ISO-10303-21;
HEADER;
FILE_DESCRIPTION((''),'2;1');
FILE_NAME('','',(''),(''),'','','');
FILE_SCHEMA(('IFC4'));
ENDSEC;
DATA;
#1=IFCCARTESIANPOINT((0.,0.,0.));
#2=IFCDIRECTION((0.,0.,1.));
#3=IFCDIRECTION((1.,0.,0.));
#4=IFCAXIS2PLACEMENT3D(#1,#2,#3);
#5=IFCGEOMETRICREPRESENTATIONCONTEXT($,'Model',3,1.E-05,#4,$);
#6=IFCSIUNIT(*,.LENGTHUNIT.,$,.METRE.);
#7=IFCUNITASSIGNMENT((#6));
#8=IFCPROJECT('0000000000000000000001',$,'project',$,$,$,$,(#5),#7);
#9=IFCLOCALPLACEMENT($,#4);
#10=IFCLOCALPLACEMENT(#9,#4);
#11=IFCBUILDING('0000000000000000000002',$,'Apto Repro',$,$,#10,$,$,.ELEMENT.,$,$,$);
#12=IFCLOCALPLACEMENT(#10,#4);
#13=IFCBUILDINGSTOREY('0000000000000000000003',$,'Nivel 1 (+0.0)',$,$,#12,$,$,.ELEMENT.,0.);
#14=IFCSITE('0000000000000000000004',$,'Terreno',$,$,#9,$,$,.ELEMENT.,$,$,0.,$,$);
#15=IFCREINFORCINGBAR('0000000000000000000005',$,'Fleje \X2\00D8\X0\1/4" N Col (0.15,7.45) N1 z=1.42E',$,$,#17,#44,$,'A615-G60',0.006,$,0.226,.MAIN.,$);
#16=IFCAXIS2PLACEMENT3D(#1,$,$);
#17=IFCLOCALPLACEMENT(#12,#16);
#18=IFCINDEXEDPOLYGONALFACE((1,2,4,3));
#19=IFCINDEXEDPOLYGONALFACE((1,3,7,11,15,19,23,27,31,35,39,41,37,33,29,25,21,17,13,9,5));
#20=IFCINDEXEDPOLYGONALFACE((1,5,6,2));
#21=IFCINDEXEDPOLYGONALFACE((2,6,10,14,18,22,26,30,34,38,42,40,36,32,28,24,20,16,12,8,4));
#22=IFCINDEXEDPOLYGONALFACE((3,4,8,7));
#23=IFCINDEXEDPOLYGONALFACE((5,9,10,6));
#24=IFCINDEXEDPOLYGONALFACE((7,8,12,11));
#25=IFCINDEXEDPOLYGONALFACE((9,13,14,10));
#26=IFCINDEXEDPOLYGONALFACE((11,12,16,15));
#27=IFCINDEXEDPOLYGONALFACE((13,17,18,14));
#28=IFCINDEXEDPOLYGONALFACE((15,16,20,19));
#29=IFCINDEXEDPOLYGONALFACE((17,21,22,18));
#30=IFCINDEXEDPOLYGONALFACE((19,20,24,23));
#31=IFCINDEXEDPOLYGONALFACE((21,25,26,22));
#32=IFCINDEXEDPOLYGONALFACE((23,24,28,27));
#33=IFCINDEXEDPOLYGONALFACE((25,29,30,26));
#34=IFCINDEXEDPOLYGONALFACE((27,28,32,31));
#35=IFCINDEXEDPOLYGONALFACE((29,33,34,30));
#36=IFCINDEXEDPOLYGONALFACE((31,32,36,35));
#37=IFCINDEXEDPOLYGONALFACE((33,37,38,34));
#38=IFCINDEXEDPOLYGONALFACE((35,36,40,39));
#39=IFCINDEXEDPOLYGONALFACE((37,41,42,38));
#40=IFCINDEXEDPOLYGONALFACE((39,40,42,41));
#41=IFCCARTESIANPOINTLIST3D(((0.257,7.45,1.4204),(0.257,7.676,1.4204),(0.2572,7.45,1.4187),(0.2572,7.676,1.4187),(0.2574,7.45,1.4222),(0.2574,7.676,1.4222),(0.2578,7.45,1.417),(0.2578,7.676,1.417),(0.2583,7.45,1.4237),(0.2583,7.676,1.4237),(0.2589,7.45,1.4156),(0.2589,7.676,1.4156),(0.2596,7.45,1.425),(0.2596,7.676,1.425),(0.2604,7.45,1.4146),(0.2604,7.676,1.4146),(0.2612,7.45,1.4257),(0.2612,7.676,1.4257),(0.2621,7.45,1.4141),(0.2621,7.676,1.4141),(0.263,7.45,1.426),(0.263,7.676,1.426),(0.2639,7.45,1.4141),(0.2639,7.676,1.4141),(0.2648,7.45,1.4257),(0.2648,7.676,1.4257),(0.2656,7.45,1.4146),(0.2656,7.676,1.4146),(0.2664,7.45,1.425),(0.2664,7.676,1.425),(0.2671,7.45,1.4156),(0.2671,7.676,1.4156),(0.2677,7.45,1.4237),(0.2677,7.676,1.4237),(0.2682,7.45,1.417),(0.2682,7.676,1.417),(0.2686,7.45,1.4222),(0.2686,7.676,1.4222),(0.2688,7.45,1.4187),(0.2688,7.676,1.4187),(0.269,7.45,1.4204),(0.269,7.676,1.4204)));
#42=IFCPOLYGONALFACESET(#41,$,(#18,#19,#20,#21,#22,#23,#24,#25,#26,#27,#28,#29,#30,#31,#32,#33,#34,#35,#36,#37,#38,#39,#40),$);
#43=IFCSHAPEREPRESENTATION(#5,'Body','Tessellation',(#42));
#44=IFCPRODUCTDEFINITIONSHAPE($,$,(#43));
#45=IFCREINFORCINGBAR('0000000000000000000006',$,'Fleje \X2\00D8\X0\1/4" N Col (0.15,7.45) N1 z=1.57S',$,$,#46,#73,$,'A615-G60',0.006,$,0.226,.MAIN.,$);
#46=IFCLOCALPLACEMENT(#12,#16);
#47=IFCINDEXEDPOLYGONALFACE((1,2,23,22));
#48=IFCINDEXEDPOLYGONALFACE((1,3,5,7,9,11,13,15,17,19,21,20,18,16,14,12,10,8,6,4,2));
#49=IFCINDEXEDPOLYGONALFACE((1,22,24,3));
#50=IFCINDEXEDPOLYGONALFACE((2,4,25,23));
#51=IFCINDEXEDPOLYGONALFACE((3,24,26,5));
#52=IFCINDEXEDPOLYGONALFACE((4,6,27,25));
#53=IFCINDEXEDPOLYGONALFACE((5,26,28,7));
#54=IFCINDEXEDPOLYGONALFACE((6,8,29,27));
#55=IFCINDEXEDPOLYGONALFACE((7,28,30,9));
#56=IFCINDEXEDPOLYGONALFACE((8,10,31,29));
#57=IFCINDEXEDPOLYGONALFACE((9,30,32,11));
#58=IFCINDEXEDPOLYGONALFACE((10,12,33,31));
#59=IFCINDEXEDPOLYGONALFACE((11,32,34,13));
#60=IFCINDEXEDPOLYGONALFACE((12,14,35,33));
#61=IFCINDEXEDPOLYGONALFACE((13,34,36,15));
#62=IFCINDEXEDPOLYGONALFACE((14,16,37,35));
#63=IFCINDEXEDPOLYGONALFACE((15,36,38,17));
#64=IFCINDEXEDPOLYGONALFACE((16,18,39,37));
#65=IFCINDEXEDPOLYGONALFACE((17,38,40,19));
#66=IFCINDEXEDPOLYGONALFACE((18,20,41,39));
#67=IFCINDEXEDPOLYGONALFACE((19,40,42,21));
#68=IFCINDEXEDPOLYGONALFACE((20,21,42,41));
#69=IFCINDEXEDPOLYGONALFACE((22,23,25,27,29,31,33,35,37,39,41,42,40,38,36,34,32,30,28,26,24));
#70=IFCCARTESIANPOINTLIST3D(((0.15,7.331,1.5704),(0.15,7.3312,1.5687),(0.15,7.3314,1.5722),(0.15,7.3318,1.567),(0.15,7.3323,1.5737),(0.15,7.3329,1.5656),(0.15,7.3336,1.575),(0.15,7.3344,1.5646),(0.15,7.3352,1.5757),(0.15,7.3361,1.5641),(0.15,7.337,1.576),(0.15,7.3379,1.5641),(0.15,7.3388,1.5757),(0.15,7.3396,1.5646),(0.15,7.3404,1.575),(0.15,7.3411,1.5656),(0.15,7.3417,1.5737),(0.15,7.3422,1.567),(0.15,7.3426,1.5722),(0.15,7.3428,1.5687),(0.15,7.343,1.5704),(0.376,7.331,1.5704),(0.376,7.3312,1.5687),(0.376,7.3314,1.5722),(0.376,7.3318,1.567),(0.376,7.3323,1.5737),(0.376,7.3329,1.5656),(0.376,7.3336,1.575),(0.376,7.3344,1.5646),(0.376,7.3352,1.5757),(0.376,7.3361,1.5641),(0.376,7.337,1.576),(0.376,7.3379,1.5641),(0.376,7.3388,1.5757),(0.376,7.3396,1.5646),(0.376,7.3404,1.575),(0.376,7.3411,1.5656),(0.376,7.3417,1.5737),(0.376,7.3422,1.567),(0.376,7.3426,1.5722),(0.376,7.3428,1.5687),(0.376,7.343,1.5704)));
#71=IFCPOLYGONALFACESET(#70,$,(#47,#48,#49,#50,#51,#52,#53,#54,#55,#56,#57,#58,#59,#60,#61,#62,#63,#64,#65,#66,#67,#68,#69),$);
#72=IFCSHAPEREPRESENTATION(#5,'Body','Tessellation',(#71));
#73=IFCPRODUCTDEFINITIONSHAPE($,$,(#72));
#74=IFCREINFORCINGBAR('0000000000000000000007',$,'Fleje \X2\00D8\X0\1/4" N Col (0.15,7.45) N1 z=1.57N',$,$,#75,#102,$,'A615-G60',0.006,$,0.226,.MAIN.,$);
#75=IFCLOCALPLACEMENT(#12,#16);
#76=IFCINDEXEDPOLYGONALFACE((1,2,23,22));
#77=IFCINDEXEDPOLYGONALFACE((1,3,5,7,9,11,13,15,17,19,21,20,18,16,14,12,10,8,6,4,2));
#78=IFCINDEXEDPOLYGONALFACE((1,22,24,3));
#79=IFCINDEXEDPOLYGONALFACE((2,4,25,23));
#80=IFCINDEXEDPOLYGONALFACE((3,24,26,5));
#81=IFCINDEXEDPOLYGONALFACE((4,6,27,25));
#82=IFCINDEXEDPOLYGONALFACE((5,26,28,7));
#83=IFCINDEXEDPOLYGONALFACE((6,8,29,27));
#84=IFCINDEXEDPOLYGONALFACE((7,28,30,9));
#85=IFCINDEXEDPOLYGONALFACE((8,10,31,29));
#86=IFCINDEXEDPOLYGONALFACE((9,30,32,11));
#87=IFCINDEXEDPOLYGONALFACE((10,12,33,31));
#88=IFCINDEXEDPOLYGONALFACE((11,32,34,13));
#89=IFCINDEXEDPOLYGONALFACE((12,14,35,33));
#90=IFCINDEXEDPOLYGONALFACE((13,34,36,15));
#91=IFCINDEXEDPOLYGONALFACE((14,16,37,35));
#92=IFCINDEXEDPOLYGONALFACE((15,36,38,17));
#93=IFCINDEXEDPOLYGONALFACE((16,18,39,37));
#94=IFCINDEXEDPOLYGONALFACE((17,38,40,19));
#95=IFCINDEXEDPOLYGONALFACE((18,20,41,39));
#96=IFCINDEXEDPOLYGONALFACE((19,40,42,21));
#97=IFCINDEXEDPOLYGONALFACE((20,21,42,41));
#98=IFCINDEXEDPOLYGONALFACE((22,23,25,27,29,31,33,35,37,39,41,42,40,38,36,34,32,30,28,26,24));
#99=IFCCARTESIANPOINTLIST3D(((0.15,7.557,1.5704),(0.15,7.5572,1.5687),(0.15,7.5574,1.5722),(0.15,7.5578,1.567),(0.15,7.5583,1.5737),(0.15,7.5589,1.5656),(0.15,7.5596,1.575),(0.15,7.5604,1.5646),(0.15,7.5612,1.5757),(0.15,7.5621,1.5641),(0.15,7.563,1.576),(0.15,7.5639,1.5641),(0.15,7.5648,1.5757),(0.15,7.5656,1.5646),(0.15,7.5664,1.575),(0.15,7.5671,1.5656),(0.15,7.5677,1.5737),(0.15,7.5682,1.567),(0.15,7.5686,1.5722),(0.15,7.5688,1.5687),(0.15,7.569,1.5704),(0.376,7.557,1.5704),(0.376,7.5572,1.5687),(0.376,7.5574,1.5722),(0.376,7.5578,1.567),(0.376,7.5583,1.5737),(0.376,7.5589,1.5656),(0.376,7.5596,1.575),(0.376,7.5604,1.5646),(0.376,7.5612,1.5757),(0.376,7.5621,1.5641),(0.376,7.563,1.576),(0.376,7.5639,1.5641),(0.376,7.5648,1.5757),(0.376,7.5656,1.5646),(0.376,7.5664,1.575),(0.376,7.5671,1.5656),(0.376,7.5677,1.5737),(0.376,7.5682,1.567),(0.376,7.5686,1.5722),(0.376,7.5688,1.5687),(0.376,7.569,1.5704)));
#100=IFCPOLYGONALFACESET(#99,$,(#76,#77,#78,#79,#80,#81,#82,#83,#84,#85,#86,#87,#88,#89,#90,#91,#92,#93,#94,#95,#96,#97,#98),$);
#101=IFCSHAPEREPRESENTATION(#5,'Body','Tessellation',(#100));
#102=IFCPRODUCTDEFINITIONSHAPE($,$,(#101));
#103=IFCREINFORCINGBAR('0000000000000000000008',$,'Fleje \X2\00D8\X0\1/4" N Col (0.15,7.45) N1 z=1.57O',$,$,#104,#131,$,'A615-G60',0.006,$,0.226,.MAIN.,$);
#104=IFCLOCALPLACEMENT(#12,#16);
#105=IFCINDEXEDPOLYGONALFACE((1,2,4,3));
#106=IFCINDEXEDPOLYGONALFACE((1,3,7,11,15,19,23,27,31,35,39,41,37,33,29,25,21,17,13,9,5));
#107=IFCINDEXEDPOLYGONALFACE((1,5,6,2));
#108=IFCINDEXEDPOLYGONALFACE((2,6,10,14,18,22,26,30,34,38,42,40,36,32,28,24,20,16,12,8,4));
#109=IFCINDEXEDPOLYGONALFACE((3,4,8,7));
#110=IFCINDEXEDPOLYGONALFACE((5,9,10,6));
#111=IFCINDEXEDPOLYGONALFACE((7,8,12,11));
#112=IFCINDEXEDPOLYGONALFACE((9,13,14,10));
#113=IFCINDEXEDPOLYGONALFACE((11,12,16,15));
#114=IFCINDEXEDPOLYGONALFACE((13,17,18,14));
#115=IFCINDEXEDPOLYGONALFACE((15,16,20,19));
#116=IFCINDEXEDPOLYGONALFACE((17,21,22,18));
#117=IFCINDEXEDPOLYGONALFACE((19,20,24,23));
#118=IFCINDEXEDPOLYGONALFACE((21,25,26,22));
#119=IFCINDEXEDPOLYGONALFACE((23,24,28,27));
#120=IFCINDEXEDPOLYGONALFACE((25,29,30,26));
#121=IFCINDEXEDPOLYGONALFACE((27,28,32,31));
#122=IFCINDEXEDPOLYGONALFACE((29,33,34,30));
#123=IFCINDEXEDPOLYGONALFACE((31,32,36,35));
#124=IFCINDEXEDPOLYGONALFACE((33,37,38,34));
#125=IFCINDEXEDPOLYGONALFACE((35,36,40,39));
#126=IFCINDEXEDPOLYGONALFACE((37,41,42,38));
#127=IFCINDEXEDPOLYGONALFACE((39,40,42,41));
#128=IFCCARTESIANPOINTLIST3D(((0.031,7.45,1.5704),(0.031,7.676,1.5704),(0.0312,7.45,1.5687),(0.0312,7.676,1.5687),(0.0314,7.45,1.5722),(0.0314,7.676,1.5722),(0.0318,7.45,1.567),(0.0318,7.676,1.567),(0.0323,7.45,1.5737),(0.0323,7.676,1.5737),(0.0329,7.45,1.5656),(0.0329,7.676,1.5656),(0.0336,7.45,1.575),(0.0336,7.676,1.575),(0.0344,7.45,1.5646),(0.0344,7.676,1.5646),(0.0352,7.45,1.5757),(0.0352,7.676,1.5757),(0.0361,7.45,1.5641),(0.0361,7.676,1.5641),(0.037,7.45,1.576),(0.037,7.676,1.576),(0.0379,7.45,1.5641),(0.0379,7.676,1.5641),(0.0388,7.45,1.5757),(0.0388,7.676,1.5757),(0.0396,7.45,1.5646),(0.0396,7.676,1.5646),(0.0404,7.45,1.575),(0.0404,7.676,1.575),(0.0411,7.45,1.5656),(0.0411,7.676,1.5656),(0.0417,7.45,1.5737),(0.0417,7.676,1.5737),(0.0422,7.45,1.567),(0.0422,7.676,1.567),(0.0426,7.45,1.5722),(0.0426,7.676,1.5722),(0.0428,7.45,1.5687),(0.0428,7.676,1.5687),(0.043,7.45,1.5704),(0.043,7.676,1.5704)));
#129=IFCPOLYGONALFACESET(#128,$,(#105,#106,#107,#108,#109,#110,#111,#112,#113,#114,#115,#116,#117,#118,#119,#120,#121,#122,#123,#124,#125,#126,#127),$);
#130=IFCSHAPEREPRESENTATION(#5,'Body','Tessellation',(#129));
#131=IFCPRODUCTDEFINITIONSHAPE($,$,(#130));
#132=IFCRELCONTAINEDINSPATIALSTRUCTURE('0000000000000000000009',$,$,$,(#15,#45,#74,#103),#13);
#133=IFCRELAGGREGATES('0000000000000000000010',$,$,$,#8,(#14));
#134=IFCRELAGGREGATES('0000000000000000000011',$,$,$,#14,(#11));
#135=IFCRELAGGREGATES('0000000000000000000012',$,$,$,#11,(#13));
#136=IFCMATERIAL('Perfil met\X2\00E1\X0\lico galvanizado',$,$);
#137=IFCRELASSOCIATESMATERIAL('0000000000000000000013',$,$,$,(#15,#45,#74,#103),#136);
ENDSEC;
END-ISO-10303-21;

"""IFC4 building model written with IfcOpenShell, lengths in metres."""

from ifc_helpers import new_model, si_unit, frame, origin_with_axes, origin_2d_with_axis, place, context, project, spatial, circle, extrude, material, element, save


model = new_model("IFC4")

# Units and contexts
model_context = context("Model", 3, precision=1e-05, world=origin_with_axes())
ifc_project = project(units=[si_unit("LENGTHUNIT", "METRE")], contexts=[model_context])

# Site, building, storey
site_placement = place(None, origin_with_axes())
site = spatial("IfcSite", under=ifc_project, at=site_placement, Name="Terreno", CompositionType="ELEMENT", RefElevation=0.0)
building_placement = place(site_placement, origin_with_axes())
building = spatial("IfcBuilding", under=site, at=building_placement, Name="Apto Repro", CompositionType="ELEMENT")
storey_placement = place(building_placement, origin_with_axes())
storey = spatial("IfcBuildingStorey", under=building, at=storey_placement, Name="Nivel 1 (+0.0)", CompositionType="ELEMENT", Elevation=0.0)

# Reinforcing bars
ifc_material = material(Name="Perfil metálico galvanizado")
reinforcing_bar_1_placement = place(storey_placement, origin_with_axes())
element("IfcReinforcingBar", 1, at=reinforcing_bar_1_placement, inside=storey, material=ifc_material, Name="Fleje Ø1/4\" N Col (0.15,7.45) N1 z=1.42E", SteelGrade="A615-G60", BarLength=0.226, NominalDiameter=0.006, PredefinedType="MAIN", context=model_context, shape_type="SweptSolid", body=[
    extrude(circle(Radius=0.006, at=origin_2d_with_axis()), frame((0.263, 7.45, 1.42), z_axis=(0.0, 1.0, 0.0), x_axis=(0.0, 0.0, 1.0)), (0.0, 0.0, 1.0), 0.226),
])
reinforcing_bar_2_placement = place(storey_placement, origin_with_axes())
element("IfcReinforcingBar", 2, at=reinforcing_bar_2_placement, inside=storey, material=ifc_material, Name="Fleje Ø1/4\" N Col (0.15,7.45) N1 z=1.57S", SteelGrade="A615-G60", BarLength=0.226, NominalDiameter=0.006, PredefinedType="MAIN", context=model_context, shape_type="SweptSolid", body=[
    extrude(circle(Radius=0.006, at=origin_2d_with_axis()), frame((0.15, 7.337, 1.57), z_axis=(1.0, 0.0, 0.0), x_axis=(0.0, 0.0, 1.0)), (0.0, 0.0, 1.0), 0.226),
])
reinforcing_bar_3_placement = place(storey_placement, origin_with_axes())
element("IfcReinforcingBar", 3, at=reinforcing_bar_3_placement, inside=storey, material=ifc_material, Name="Fleje Ø1/4\" N Col (0.15,7.45) N1 z=1.57N", SteelGrade="A615-G60", BarLength=0.226, NominalDiameter=0.006, PredefinedType="MAIN", context=model_context, shape_type="SweptSolid", body=[
    extrude(circle(Radius=0.006, at=origin_2d_with_axis()), frame((0.15, 7.563, 1.57), z_axis=(1.0, 0.0, 0.0), x_axis=(0.0, 0.0, 1.0)), (0.0, 0.0, 1.0), 0.226),
])
reinforcing_bar_4_placement = place(storey_placement, origin_with_axes())
element("IfcReinforcingBar", 4, at=reinforcing_bar_4_placement, inside=storey, material=ifc_material, Name="Fleje Ø1/4\" N Col (0.15,7.45) N1 z=1.57O", SteelGrade="A615-G60", BarLength=0.226, NominalDiameter=0.006, PredefinedType="MAIN", context=model_context, shape_type="SweptSolid", body=[
    extrude(circle(Radius=0.006, at=origin_2d_with_axis()), frame((0.037, 7.45, 1.57), z_axis=(0.0, 1.0, 0.0), x_axis=(0.0, 0.0, 1.0)), (0.0, 0.0, 1.0), 0.226),
])

save(model, "model.ifc")
